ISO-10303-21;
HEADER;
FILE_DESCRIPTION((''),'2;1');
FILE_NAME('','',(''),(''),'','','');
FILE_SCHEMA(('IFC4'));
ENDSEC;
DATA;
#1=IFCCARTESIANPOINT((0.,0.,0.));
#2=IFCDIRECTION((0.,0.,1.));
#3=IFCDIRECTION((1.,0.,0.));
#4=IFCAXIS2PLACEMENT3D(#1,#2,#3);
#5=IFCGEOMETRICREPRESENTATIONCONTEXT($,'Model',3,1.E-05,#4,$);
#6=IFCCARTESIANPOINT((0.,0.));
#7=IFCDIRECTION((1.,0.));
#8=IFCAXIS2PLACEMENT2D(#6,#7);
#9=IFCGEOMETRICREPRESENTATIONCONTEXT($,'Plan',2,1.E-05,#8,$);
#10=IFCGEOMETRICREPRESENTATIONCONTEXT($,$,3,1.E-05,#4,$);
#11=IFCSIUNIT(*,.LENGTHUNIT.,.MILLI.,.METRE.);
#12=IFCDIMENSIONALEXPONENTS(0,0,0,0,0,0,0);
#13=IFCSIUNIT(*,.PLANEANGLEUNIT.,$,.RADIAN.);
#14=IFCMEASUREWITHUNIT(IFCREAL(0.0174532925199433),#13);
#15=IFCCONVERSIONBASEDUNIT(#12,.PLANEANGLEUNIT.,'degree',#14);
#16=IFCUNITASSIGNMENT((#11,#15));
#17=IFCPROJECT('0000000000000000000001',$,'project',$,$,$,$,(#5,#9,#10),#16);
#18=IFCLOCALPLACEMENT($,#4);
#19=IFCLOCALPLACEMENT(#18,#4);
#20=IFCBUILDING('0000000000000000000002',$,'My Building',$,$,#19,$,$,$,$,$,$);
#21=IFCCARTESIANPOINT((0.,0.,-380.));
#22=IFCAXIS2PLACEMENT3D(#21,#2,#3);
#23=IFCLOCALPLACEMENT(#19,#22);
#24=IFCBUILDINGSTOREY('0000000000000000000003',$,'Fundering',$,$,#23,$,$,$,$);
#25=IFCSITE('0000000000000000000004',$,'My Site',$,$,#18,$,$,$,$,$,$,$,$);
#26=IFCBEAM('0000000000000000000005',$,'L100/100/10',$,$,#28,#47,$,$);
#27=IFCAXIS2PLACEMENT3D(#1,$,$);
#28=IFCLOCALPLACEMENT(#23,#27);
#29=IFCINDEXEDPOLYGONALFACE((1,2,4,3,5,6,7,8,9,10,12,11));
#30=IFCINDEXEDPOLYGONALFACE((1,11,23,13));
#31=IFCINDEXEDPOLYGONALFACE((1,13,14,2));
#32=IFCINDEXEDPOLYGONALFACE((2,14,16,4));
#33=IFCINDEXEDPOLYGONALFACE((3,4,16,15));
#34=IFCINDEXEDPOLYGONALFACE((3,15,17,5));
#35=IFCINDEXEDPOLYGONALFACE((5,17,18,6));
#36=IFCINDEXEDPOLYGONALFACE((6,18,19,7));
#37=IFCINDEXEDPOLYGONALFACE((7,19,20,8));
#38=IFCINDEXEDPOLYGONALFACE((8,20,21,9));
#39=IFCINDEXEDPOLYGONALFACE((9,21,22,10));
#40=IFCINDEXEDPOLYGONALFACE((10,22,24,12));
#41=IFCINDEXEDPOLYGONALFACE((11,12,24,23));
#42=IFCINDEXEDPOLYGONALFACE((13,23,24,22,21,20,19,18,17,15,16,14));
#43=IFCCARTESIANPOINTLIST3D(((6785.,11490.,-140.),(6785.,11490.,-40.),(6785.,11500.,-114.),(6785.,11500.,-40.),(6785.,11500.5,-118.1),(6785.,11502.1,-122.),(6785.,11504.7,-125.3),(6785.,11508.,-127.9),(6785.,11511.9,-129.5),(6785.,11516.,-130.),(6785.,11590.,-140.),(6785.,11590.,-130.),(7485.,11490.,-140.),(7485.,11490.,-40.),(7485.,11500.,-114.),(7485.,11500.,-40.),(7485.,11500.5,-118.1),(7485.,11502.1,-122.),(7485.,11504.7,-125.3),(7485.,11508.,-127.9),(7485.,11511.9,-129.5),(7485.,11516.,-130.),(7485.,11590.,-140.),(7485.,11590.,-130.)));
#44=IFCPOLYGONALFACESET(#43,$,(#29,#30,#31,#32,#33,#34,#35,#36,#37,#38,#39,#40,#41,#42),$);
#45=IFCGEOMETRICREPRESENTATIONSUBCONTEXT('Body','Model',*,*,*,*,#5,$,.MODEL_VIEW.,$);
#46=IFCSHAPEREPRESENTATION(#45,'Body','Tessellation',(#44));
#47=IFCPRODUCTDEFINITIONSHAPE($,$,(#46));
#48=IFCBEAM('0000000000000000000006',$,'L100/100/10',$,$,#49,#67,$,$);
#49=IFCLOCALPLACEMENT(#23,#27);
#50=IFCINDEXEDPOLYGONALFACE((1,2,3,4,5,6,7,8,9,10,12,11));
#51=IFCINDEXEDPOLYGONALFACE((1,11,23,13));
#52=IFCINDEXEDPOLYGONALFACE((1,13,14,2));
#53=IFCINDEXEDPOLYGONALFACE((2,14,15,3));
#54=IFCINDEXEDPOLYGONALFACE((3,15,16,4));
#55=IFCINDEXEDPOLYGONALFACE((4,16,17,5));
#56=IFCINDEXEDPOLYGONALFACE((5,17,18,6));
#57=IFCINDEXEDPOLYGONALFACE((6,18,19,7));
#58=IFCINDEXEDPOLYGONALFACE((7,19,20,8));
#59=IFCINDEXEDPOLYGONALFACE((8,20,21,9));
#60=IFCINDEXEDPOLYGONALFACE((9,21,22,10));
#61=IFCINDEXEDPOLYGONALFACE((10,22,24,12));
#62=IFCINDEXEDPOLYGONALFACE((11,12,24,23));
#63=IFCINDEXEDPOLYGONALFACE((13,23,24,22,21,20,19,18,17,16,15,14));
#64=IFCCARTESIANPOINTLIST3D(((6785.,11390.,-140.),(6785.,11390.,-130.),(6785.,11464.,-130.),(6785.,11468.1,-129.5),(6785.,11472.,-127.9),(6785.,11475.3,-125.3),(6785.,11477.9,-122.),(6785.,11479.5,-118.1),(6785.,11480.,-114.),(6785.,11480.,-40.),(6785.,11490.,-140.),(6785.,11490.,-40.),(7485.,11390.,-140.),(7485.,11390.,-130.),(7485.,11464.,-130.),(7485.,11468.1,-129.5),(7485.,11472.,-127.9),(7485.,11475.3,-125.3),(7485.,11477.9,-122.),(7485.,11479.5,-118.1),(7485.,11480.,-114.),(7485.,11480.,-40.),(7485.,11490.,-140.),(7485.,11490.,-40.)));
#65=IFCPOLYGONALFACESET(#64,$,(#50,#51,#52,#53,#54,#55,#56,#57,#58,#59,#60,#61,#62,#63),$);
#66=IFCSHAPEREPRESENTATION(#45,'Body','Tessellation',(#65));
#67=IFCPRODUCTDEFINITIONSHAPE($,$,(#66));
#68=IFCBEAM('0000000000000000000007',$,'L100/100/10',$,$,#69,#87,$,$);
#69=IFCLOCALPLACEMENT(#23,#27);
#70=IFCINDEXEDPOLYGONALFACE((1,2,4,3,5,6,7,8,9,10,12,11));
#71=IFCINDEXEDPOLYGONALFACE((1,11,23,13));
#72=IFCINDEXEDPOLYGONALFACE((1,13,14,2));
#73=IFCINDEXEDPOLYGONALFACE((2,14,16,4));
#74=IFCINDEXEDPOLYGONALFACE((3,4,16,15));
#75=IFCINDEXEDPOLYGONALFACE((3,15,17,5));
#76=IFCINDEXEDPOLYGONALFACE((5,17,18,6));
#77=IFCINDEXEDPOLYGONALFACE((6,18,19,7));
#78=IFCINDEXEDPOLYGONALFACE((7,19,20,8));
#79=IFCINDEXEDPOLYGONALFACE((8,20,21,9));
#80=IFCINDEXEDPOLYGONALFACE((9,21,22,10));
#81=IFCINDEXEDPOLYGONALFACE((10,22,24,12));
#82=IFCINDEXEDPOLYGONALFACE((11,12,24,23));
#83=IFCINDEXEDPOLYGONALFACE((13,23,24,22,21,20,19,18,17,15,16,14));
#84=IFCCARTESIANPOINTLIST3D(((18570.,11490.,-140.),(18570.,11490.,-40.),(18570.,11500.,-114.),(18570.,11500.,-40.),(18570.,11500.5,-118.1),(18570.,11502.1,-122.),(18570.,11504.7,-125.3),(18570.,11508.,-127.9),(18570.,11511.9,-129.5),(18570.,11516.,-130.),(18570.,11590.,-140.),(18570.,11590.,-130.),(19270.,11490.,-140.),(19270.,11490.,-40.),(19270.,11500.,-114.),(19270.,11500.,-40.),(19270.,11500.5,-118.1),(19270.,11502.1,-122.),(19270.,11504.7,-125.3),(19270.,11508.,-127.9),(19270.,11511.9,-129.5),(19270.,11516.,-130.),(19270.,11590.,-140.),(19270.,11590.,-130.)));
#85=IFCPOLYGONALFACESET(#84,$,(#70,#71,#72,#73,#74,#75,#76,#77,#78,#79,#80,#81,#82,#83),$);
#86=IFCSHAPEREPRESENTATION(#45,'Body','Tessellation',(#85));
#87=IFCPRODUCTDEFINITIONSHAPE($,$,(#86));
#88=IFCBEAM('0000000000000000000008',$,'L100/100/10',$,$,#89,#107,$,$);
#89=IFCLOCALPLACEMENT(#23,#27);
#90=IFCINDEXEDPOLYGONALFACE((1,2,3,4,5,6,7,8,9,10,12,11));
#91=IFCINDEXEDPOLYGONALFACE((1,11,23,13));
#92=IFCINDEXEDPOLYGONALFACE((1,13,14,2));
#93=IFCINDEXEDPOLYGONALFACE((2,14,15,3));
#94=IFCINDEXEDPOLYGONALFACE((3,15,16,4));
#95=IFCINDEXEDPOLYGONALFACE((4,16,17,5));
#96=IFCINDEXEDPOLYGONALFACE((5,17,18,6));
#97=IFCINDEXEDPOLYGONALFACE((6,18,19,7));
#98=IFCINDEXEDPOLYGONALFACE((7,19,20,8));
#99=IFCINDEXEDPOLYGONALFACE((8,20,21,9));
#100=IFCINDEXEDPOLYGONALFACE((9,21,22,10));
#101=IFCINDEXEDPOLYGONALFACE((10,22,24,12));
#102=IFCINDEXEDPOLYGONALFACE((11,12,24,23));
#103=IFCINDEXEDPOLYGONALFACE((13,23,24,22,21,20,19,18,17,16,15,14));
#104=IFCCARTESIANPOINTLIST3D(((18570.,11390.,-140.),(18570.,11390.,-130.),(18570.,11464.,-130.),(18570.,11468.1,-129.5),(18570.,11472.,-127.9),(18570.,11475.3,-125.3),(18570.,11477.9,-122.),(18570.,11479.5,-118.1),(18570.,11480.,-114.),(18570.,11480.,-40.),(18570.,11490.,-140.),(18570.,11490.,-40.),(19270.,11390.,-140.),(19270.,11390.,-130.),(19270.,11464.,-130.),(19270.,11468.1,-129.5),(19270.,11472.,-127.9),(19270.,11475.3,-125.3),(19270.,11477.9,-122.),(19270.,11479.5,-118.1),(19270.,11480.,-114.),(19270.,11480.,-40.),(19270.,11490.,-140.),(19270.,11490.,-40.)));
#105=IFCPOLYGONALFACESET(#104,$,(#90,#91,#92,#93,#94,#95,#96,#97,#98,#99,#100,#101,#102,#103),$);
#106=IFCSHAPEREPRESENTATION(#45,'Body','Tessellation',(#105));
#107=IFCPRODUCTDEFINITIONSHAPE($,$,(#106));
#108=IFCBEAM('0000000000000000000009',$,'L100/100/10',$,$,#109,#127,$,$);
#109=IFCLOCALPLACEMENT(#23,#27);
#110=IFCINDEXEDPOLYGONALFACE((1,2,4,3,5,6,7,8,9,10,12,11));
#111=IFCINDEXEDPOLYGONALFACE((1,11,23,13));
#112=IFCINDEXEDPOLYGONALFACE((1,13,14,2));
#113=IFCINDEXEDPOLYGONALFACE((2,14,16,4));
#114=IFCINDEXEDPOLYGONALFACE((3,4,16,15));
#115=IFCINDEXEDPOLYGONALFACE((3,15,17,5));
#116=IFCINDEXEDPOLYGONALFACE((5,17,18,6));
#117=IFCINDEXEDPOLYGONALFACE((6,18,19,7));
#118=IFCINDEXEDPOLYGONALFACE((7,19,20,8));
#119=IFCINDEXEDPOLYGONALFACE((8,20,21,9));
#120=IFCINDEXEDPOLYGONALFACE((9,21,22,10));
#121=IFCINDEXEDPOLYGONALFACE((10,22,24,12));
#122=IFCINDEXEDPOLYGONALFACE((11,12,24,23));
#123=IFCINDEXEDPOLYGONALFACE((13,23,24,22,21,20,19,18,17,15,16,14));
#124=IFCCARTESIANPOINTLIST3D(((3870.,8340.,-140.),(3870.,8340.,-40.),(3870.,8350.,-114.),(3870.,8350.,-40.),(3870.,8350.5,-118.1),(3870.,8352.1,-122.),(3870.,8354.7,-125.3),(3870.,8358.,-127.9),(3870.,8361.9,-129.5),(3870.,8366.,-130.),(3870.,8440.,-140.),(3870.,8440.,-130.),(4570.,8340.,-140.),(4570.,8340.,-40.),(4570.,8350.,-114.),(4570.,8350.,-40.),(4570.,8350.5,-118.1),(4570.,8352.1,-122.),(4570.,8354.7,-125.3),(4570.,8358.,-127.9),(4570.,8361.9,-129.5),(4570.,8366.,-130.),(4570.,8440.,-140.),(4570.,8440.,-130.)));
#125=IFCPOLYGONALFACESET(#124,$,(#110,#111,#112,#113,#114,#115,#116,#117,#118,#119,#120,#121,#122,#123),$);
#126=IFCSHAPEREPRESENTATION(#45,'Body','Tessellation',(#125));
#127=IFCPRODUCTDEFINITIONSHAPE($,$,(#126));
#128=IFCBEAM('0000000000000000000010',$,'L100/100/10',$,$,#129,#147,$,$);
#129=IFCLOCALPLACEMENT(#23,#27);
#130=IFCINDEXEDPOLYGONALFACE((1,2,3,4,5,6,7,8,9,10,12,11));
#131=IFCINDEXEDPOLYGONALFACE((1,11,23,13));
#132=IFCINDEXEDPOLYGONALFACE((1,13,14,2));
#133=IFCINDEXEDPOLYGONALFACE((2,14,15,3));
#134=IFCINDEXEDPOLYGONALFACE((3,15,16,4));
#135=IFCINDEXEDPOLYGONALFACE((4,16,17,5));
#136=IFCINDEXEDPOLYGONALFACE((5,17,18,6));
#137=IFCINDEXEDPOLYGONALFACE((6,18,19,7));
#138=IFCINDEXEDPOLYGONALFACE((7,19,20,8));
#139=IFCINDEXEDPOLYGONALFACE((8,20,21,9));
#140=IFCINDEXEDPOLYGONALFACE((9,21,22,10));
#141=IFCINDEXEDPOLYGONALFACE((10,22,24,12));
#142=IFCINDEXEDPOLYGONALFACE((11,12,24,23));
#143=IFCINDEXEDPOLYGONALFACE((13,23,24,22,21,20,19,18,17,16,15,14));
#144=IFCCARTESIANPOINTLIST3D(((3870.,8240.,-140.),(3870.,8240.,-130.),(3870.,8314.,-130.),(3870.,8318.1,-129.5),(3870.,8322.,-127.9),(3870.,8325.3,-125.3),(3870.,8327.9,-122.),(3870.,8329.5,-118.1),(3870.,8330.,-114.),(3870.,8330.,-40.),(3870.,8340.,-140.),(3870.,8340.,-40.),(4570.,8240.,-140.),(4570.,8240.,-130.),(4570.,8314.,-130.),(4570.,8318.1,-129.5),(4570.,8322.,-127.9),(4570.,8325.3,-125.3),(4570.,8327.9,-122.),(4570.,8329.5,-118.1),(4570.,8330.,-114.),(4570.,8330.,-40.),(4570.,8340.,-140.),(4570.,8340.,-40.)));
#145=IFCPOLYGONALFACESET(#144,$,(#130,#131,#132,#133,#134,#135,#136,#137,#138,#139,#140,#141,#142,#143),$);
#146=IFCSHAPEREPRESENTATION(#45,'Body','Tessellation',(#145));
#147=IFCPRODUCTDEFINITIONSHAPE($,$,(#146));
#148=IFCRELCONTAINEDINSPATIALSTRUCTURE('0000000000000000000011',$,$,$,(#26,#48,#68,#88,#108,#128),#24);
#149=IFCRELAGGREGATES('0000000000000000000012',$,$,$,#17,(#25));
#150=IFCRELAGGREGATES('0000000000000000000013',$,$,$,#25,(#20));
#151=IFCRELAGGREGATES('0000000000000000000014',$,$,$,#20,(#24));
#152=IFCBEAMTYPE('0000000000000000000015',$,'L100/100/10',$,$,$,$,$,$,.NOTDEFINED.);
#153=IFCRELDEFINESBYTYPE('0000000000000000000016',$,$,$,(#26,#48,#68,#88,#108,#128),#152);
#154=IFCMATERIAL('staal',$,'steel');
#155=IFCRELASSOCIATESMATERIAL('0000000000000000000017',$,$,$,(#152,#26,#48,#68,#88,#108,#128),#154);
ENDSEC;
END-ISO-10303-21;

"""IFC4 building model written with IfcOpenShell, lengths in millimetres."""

from ifc_helpers import new_model, entity, si_unit, converted_unit, frame, origin_with_axes, origin_2d_with_axis, place, context, subcontext, project, spatial, l_section, extrude, material, material_profile, profile_set, profile_usage, type_object, element, save


model = new_model("IFC4")

# Units and contexts
model_context = context("Model", 3, precision=1e-05, world=origin_with_axes())
plan_context = context("Plan", 2, precision=1e-05, world=origin_2d_with_axis())
context_of_model = context(None, 3, precision=1e-05, world=origin_with_axes())
body_context = subcontext(model_context, "Body", "Model", "MODEL_VIEW")
ifc_project = project(units=[si_unit("LENGTHUNIT", "METRE", prefix="MILLI"), converted_unit("PLANEANGLEUNIT", "degree", entity("IfcReal", 0.0174532925199433), si_unit("PLANEANGLEUNIT", "RADIAN"), dimensions=[0, 0, 0, 0, 0, 0, 0])], contexts=[model_context, plan_context, context_of_model])

# Site, building, storey
site_placement = place(None, origin_with_axes())
site = spatial("IfcSite", under=ifc_project, at=site_placement, Name="My Site")
building_placement = place(site_placement, origin_with_axes())
building = spatial("IfcBuilding", under=site, at=building_placement, Name="My Building")
storey_placement = place(building_placement, frame((0.0, 0.0, -380.0), z_axis=(0.0, 0.0, 1.0), x_axis=(1.0, 0.0, 0.0)))
storey = spatial("IfcBuildingStorey", under=building, at=storey_placement, Name="Fundering")

# Beams
ifc_material_1 = material(Name="staal", Category="steel")
ifc_material_profile_1 = material_profile(ifc_material_1, l_section(Depth=100.0, Width=100.0, Thickness=10.0, FilletRadius=16.0))
ifc_profile_set_1 = profile_set([ifc_material_profile_1], Name="L100/100/10")
beam_type_1 = type_object("IfcBeamType", Name="L100/100/10", PredefinedType="NOTDEFINED", material=ifc_profile_set_1)
ifc_profile_usage_1 = profile_usage(ifc_profile_set_1, cardinal=5)
beam_1_placement = place(storey_placement, frame((6785.0, 11540.0, -90.0), z_axis=(1.0, 0.0, 0.0), x_axis=(0.0, 1.0, 0.0)))
element("IfcBeam", 1, at=beam_1_placement, inside=storey, type_object=beam_type_1, material=ifc_profile_usage_1, Name="L100/100/10", context=body_context, shape_type="SweptSolid", body=[
    extrude(l_section(Depth=100.0, Width=100.0, Thickness=10.0, FilletRadius=16.0), origin_with_axes(), (0.0, 0.0, 1.0), 700.0),
])
ifc_profile_usage_2 = profile_usage(ifc_profile_set_1, cardinal=5)
beam_2_placement = place(storey_placement, frame((7485.0, 11440.0, -90.0), z_axis=(-1.0, 0.0, 0.0), x_axis=(0.0, -1.0, 0.0)))
element("IfcBeam", 2, at=beam_2_placement, inside=storey, type_object=beam_type_1, material=ifc_profile_usage_2, Name="L100/100/10", context=body_context, shape_type="SweptSolid", body=[
    extrude(l_section(Depth=100.0, Width=100.0, Thickness=10.0, FilletRadius=16.0), origin_with_axes(), (0.0, 0.0, 1.0), 700.0),
])
ifc_profile_usage_3 = profile_usage(ifc_profile_set_1, cardinal=5)
beam_3_placement = place(storey_placement, frame((18570.0, 11540.0, -90.0), z_axis=(1.0, 0.0, 0.0), x_axis=(0.0, 1.0, 0.0)))
element("IfcBeam", 3, at=beam_3_placement, inside=storey, type_object=beam_type_1, material=ifc_profile_usage_3, Name="L100/100/10", context=body_context, shape_type="SweptSolid", body=[
    extrude(l_section(Depth=100.0, Width=100.0, Thickness=10.0, FilletRadius=16.0), origin_with_axes(), (0.0, 0.0, 1.0), 700.0),
])
ifc_profile_usage_4 = profile_usage(ifc_profile_set_1, cardinal=5)
beam_4_placement = place(storey_placement, frame((19270.0, 11440.0, -90.0), z_axis=(-1.0, 0.0, 0.0), x_axis=(0.0, -1.0, 0.0)))
element("IfcBeam", 4, at=beam_4_placement, inside=storey, type_object=beam_type_1, material=ifc_profile_usage_4, Name="L100/100/10", context=body_context, shape_type="SweptSolid", body=[
    extrude(l_section(Depth=100.0, Width=100.0, Thickness=10.0, FilletRadius=16.0), origin_with_axes(), (0.0, 0.0, 1.0), 700.0),
])
ifc_profile_usage_5 = profile_usage(ifc_profile_set_1, cardinal=5)
beam_5_placement = place(storey_placement, frame((3870.0, 8390.0, -90.0), z_axis=(1.0, 0.0, 0.0), x_axis=(0.0, 1.0, 0.0)))
element("IfcBeam", 5, at=beam_5_placement, inside=storey, type_object=beam_type_1, material=ifc_profile_usage_5, Name="L100/100/10", context=body_context, shape_type="SweptSolid", body=[
    extrude(l_section(Depth=100.0, Width=100.0, Thickness=10.0, FilletRadius=16.0), origin_with_axes(), (0.0, 0.0, 1.0), 700.0),
])
ifc_profile_usage_6 = profile_usage(ifc_profile_set_1, cardinal=5)
beam_6_placement = place(storey_placement, frame((4570.0, 8290.0, -90.0), z_axis=(-1.0, 0.0, 0.0), x_axis=(0.0, -1.0, 0.0)))
element("IfcBeam", 6, at=beam_6_placement, inside=storey, type_object=beam_type_1, material=ifc_profile_usage_6, Name="L100/100/10", context=body_context, shape_type="SweptSolid", body=[
    extrude(l_section(Depth=100.0, Width=100.0, Thickness=10.0, FilletRadius=16.0), origin_with_axes(), (0.0, 0.0, 1.0), 700.0),
])

save(model, "model.ifc")
